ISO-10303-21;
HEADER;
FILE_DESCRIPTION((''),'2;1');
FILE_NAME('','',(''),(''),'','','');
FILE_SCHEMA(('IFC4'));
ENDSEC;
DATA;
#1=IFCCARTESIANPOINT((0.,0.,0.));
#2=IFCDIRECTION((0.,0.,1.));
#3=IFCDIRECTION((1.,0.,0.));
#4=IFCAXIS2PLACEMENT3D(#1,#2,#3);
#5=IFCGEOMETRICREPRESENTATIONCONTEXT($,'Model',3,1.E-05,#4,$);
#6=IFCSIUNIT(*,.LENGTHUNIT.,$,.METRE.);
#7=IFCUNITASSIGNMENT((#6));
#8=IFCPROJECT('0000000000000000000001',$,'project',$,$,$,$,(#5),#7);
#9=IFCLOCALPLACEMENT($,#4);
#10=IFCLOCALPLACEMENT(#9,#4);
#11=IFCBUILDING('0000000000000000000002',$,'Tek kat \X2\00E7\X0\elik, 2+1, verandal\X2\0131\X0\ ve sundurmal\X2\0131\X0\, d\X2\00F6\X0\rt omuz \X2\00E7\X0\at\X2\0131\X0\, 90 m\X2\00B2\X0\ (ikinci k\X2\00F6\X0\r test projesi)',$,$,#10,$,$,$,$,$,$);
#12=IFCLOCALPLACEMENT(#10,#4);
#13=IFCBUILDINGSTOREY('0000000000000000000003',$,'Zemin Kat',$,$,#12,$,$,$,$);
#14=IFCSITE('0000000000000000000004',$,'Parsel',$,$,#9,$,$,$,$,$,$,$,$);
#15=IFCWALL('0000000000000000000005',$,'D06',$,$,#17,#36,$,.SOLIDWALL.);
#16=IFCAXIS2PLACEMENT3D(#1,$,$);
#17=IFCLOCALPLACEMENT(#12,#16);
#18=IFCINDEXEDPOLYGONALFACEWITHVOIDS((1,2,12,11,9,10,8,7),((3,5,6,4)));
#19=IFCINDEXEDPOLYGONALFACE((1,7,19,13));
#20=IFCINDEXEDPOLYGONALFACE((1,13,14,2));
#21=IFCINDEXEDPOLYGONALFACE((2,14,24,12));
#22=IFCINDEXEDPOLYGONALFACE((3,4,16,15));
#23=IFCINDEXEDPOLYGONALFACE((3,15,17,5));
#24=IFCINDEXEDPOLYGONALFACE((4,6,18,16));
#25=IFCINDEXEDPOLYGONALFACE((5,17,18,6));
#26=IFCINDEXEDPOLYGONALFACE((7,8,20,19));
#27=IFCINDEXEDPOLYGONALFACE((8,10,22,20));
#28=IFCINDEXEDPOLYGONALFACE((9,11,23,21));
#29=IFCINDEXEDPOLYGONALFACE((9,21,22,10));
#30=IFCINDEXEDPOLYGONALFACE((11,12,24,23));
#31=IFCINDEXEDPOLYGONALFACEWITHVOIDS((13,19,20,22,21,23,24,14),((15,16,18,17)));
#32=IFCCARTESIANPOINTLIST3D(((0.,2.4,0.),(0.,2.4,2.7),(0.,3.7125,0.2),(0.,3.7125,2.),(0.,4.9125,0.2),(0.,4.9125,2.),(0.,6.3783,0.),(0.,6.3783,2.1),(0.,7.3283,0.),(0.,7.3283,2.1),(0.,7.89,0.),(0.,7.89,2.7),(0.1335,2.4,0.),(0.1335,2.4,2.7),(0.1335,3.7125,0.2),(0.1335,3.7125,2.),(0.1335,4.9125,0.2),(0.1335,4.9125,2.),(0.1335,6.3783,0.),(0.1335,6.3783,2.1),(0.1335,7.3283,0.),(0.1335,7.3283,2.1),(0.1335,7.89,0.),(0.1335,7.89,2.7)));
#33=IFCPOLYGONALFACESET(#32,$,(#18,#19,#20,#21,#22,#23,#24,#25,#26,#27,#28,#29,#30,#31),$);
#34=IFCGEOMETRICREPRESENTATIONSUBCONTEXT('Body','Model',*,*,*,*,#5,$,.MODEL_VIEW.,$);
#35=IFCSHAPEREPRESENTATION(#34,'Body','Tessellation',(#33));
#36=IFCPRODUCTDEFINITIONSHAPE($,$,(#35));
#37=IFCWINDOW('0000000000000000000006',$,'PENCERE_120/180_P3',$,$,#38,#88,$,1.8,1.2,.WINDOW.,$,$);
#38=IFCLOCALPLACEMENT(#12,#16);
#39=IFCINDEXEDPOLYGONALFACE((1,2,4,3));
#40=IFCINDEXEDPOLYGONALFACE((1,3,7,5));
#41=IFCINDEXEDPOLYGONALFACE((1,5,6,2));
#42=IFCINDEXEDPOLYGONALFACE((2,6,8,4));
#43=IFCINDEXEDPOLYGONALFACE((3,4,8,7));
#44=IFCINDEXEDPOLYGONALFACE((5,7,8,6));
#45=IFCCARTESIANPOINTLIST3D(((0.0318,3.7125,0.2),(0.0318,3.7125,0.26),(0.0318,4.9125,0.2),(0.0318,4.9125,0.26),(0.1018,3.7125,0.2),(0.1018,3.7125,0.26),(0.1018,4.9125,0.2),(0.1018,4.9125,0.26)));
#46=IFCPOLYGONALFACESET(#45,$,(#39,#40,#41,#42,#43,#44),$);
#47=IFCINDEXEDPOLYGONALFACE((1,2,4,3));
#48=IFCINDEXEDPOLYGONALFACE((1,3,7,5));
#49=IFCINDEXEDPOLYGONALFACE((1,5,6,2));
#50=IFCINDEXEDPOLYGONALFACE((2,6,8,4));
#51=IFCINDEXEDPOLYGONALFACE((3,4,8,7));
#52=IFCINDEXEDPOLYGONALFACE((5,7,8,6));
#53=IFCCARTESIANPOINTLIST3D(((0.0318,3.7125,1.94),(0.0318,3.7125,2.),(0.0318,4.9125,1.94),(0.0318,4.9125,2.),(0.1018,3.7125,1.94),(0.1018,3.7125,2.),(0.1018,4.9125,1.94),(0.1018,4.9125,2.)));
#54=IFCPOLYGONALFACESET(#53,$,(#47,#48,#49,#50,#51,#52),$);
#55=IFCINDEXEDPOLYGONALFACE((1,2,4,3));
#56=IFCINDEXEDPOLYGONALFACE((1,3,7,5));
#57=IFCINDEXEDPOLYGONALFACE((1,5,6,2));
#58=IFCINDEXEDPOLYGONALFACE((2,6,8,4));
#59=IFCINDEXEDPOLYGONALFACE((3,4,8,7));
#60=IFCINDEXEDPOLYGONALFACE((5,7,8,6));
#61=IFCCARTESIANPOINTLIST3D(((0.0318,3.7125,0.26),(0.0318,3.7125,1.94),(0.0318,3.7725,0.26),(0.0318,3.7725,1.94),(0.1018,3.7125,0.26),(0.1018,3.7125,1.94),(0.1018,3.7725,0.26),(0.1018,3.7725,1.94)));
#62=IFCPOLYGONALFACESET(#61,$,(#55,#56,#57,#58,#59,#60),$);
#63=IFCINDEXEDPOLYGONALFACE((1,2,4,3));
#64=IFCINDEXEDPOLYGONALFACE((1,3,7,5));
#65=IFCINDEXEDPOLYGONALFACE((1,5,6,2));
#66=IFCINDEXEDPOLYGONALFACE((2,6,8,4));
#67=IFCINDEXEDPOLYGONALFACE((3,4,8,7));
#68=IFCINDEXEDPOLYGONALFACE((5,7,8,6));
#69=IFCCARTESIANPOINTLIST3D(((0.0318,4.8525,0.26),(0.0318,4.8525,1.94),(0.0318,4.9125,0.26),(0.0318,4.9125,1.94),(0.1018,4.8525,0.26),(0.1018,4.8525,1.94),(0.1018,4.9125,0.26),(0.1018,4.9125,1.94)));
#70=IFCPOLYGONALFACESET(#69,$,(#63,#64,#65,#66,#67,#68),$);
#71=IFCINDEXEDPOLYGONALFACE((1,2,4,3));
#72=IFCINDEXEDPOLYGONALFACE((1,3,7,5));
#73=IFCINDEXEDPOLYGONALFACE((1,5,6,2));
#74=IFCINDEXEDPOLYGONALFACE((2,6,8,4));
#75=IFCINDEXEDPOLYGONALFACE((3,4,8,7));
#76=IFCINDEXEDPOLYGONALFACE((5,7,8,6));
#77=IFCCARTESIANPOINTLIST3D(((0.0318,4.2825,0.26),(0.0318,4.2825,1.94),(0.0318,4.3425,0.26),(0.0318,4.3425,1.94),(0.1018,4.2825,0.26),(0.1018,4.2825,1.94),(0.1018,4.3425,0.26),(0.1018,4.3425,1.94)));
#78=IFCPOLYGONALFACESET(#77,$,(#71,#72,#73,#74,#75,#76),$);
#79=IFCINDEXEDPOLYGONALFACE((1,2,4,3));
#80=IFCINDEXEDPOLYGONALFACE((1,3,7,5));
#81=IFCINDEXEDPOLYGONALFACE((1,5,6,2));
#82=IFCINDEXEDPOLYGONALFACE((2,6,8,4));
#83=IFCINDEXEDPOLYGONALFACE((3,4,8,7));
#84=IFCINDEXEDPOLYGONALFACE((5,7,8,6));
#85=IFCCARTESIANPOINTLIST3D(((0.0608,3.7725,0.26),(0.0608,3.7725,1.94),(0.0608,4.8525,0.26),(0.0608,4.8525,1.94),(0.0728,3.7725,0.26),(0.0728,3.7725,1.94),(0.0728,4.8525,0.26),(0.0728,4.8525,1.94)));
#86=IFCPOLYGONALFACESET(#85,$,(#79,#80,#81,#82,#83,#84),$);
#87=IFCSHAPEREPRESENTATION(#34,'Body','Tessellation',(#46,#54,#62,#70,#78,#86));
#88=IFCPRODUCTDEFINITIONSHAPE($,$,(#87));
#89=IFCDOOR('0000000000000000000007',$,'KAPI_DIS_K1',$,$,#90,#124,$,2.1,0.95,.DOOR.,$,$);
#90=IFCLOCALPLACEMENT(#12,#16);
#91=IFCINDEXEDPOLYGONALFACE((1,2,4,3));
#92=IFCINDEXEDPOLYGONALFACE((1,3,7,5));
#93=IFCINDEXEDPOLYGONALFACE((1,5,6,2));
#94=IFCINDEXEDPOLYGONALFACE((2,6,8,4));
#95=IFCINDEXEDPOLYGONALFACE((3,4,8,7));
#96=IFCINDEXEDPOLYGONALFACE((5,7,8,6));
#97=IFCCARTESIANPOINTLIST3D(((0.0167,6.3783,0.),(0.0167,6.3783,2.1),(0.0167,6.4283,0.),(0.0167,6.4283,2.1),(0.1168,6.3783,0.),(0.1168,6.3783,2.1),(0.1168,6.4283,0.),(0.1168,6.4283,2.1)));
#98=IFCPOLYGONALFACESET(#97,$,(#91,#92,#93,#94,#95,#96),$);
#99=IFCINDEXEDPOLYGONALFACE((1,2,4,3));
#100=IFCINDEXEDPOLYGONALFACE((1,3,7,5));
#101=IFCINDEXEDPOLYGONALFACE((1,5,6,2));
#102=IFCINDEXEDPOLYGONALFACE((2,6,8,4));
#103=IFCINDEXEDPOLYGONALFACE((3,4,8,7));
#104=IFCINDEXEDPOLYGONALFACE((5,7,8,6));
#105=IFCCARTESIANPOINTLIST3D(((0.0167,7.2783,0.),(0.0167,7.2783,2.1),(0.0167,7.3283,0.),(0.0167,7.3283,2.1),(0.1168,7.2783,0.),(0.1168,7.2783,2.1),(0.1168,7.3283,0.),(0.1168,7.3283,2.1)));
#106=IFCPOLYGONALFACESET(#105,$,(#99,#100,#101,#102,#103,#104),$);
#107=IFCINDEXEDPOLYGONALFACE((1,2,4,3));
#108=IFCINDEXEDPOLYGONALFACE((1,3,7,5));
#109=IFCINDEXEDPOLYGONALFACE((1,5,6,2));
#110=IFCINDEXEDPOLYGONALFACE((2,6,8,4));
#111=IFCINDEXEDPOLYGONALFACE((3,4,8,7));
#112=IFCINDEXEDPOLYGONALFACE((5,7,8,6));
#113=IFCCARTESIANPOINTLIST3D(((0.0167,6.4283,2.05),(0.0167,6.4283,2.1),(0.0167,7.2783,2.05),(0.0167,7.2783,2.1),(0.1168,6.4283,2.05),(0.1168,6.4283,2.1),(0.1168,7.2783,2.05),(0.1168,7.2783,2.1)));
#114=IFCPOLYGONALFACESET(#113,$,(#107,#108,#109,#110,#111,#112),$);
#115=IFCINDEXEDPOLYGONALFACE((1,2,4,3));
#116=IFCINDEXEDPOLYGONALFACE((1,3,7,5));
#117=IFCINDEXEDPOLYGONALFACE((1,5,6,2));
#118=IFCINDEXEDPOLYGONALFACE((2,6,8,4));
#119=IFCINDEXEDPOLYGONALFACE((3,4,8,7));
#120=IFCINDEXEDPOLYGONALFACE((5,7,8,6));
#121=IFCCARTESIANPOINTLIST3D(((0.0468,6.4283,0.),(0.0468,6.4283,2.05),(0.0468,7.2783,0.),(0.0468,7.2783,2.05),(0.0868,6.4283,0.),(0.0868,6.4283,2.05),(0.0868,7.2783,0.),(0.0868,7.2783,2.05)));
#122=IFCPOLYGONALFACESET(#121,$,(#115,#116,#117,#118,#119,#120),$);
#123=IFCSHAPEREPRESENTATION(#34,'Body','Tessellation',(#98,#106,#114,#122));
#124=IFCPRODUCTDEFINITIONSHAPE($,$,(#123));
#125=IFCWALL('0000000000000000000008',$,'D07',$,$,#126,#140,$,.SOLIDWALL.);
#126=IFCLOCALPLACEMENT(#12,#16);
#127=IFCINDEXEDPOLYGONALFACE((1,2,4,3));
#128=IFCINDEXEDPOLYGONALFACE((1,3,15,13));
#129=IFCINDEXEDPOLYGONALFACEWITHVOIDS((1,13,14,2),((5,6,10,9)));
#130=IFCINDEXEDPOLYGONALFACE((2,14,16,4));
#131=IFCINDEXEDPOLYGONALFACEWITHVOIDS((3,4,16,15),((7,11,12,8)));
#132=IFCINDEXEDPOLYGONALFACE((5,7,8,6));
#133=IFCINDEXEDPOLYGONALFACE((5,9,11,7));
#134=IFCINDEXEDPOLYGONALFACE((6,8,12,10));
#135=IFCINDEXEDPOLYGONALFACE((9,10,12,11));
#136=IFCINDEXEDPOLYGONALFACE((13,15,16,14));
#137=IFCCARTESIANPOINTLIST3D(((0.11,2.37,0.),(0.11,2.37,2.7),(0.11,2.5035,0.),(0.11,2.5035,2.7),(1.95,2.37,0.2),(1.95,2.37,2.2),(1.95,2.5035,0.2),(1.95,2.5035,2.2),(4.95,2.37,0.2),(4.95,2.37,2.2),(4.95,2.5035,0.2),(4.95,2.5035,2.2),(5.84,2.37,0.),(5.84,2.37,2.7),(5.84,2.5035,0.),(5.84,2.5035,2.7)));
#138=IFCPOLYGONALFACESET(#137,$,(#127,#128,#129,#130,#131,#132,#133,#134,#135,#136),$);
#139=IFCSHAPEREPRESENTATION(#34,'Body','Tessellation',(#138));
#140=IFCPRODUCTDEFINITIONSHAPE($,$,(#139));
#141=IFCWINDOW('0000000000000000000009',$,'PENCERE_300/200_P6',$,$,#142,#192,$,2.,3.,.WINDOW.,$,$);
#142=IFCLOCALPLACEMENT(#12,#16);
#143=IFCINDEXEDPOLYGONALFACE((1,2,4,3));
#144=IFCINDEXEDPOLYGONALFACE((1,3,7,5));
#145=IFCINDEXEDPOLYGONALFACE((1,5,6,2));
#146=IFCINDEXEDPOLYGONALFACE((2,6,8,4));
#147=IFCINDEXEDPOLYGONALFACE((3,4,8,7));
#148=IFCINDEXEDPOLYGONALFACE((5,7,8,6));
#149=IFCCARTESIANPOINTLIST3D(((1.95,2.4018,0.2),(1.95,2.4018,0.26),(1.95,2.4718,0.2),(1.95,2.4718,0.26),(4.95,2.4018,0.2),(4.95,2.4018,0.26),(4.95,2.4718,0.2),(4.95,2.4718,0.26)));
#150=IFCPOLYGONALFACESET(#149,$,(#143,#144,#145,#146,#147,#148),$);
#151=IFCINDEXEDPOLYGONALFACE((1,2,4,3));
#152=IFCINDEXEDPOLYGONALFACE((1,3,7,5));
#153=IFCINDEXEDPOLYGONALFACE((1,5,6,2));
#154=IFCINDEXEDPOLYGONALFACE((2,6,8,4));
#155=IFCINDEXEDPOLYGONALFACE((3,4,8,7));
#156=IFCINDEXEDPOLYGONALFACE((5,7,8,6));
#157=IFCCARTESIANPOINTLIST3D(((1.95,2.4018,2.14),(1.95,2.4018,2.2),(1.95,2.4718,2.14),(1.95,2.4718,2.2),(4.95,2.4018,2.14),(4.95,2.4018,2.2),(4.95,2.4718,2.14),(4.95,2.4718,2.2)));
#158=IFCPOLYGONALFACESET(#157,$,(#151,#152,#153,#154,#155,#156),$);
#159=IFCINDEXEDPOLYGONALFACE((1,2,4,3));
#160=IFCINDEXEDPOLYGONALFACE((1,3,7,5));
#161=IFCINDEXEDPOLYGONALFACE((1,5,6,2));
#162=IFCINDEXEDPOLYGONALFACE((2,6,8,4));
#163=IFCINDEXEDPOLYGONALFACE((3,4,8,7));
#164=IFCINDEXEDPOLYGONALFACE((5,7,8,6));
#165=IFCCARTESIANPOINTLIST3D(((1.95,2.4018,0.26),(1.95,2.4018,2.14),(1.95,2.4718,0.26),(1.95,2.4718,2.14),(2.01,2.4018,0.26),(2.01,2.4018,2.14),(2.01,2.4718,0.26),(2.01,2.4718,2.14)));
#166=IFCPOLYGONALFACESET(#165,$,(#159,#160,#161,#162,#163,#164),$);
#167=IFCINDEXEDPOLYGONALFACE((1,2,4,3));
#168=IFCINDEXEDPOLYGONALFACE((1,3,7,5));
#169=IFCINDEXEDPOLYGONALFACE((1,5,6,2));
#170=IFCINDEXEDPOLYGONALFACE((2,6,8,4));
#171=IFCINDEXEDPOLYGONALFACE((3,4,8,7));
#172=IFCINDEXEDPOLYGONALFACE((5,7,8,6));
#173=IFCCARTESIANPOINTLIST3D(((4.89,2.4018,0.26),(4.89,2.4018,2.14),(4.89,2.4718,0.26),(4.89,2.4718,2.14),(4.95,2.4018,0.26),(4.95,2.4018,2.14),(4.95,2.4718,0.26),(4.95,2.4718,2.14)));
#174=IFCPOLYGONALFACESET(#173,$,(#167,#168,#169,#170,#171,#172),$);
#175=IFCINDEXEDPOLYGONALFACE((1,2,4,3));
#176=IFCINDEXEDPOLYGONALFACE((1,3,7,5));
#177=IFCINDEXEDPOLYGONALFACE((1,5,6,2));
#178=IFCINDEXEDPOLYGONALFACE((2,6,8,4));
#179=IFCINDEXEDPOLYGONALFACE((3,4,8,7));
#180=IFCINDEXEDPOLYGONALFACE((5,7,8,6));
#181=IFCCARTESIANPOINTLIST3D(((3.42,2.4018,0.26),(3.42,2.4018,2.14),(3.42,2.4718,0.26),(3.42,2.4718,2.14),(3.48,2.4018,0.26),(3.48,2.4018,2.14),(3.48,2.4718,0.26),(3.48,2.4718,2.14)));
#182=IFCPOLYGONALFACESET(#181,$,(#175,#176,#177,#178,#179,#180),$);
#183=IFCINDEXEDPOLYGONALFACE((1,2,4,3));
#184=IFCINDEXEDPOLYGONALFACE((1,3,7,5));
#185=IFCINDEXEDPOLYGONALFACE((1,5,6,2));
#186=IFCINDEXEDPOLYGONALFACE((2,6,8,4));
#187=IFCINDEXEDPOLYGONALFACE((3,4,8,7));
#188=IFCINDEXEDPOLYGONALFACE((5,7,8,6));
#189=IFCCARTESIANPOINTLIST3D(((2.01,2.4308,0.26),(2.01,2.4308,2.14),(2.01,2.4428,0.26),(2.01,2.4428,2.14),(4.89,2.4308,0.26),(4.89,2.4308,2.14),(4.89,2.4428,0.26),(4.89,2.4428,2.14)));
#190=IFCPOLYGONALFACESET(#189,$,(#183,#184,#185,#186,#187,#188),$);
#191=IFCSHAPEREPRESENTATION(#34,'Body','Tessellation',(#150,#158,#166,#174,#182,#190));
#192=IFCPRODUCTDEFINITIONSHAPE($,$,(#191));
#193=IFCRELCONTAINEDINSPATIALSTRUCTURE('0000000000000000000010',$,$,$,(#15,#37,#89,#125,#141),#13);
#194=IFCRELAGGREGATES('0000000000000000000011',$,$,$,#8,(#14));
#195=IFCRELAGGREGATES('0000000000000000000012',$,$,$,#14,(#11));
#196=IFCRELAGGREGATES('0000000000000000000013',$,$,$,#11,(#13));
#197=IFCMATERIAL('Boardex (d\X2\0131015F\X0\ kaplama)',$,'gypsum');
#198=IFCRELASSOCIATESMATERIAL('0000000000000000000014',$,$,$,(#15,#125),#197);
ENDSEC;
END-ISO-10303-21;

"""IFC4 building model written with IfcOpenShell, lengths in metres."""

from ifc_helpers import new_model, si_unit, frame, origin_with_axes, place, context, subcontext, project, spatial, line, indexed_curve, outline, extrude, material, element, fill, save


model = new_model("IFC4")

# Units and contexts
model_context = context("Model", 3, precision=1e-05, world=origin_with_axes())
body_context = subcontext(model_context, "Body", "Model", "MODEL_VIEW")
ifc_project = project(units=[si_unit("LENGTHUNIT", "METRE")], contexts=[model_context])

# Site, building, storey
site_placement = place(None, origin_with_axes())
site = spatial("IfcSite", under=ifc_project, at=site_placement, Name="Parsel")
building_placement = place(site_placement, origin_with_axes())
building = spatial("IfcBuilding", under=site, at=building_placement, Name="Tek kat çelik, 2+1, verandalı ve sundurmalı, dört omuz çatı, 90 m² (ikinci kör test projesi)")
storey_placement = place(building_placement, origin_with_axes())
storey = spatial("IfcBuildingStorey", under=building, at=storey_placement, Name="Zemin Kat")

# Shared definitions
ifc_material_1 = material(Name="Boardex (dış kaplama)", Category="gypsum")

# Wall, openings, window, door
wall_1_placement = place(storey_placement, origin_with_axes())
wall_1 = element("IfcWall", 1, at=wall_1_placement, inside=storey, material=ifc_material_1, Name="D06", PredefinedType="SOLIDWALL", context=body_context, shape_type="SweptSolid", body=[
    extrude(outline(indexed_curve([(0.0, 0.0), (0.1335, 0.0), (0.1335, 5.49), (0.0, 5.49)], segments=[line(1, 2, 3, 4, 1)])), frame((0.0, 2.4, 0.0), z_axis=(0.0, 0.0, 1.0), x_axis=(1.0, 0.0, 0.0)), (0.0, 0.0, 1.0), 2.7),
])
opening_1_placement = place(wall_1_placement, origin_with_axes())
opening_1 = element("IfcOpeningElement", 2, at=opening_1_placement, cuts=wall_1, PredefinedType="OPENING", context=body_context, shape_type="SweptSolid", body=[
    extrude(outline(indexed_curve([(0.0, 0.0), (0.1735, 0.0), (0.1735, 1.2), (0.0, 1.2)], segments=[line(1, 2, 3, 4, 1)])), frame((-0.02, 3.7125, 0.2), z_axis=(0.0, 0.0, 1.0), x_axis=(1.0, 0.0, 0.0)), (0.0, 0.0, 1.0), 1.8),
])
opening_2_placement = place(wall_1_placement, origin_with_axes())
opening_2 = element("IfcOpeningElement", 3, at=opening_2_placement, cuts=wall_1, PredefinedType="OPENING", context=body_context, shape_type="SweptSolid", body=[
    extrude(outline(indexed_curve([(0.0, 0.0), (0.1735, 0.0), (0.1735, 0.95), (0.0, 0.95)], segments=[line(1, 2, 3, 4, 1)])), frame((-0.02, 6.3783, 0.0), z_axis=(0.0, 0.0, 1.0), x_axis=(1.0, 0.0, 0.0)), (0.0, 0.0, 1.0), 2.1),
])
window_1_placement = place(storey_placement, origin_with_axes())
window_1 = element("IfcWindow", 4, at=window_1_placement, inside=storey, Name="PENCERE_120/180_P3", OverallHeight=1.8, OverallWidth=1.2, PredefinedType="WINDOW", context=body_context, shape_type="SweptSolid", body=[
    extrude(outline(indexed_curve([(0.0, 0.0), (0.07, 0.0), (0.07, 1.2), (0.0, 1.2)], segments=[line(1, 2, 3, 4, 1)])), frame((0.0318, 3.7125, 0.2), z_axis=(0.0, 0.0, 1.0), x_axis=(1.0, 0.0, 0.0)), (0.0, 0.0, 1.0), 0.06),
    extrude(outline(indexed_curve([(0.0, 0.0), (0.07, 0.0), (0.07, 1.2), (0.0, 1.2)], segments=[line(1, 2, 3, 4, 1)])), frame((0.0318, 3.7125, 1.94), z_axis=(0.0, 0.0, 1.0), x_axis=(1.0, 0.0, 0.0)), (0.0, 0.0, 1.0), 0.06),
    extrude(outline(indexed_curve([(0.0, 0.0), (0.07, 0.0), (0.07, 0.06), (0.0, 0.06)], segments=[line(1, 2, 3, 4, 1)])), frame((0.0318, 3.7125, 0.26), z_axis=(0.0, 0.0, 1.0), x_axis=(1.0, 0.0, 0.0)), (0.0, 0.0, 1.0), 1.68),
    extrude(outline(indexed_curve([(0.0, 0.0), (0.07, 0.0), (0.07, 0.06), (0.0, 0.06)], segments=[line(1, 2, 3, 4, 1)])), frame((0.0318, 4.8525, 0.26), z_axis=(0.0, 0.0, 1.0), x_axis=(1.0, 0.0, 0.0)), (0.0, 0.0, 1.0), 1.68),
    extrude(outline(indexed_curve([(0.0, 0.0), (0.07, 0.0), (0.07, 0.06), (0.0, 0.06)], segments=[line(1, 2, 3, 4, 1)])), frame((0.0318, 4.2825, 0.26), z_axis=(0.0, 0.0, 1.0), x_axis=(1.0, 0.0, 0.0)), (0.0, 0.0, 1.0), 1.68),
    extrude(outline(indexed_curve([(0.0, 0.0), (0.012, 0.0), (0.012, 1.08), (0.0, 1.08)], segments=[line(1, 2, 3, 4, 1)])), frame((0.0608, 3.7725, 0.26), z_axis=(0.0, 0.0, 1.0), x_axis=(1.0, 0.0, 0.0)), (0.0, 0.0, 1.0), 1.68),
])
fill(opening_1, window_1)
door_1_placement = place(storey_placement, origin_with_axes())
door_1 = element("IfcDoor", 5, at=door_1_placement, inside=storey, Name="KAPI_DIS_K1", OverallHeight=2.1, OverallWidth=0.95, PredefinedType="DOOR", context=body_context, shape_type="SweptSolid", body=[
    extrude(outline(indexed_curve([(0.0, 0.0), (0.1, 0.0), (0.1, 0.05), (0.0, 0.05)], segments=[line(1, 2, 3, 4, 1)])), frame((0.0167, 6.3783, 0.0), z_axis=(0.0, 0.0, 1.0), x_axis=(1.0, 0.0, 0.0)), (0.0, 0.0, 1.0), 2.1),
    extrude(outline(indexed_curve([(0.0, 0.0), (0.1, 0.0), (0.1, 0.05), (0.0, 0.05)], segments=[line(1, 2, 3, 4, 1)])), frame((0.0167, 7.2783, 0.0), z_axis=(0.0, 0.0, 1.0), x_axis=(1.0, 0.0, 0.0)), (0.0, 0.0, 1.0), 2.1),
    extrude(outline(indexed_curve([(0.0, 0.0), (0.1, 0.0), (0.1, 0.85), (0.0, 0.85)], segments=[line(1, 2, 3, 4, 1)])), frame((0.0167, 6.4283, 2.05), z_axis=(0.0, 0.0, 1.0), x_axis=(1.0, 0.0, 0.0)), (0.0, 0.0, 1.0), 0.05),
    extrude(outline(indexed_curve([(0.0, 0.0), (0.04, 0.0), (0.04, 0.85), (0.0, 0.85)], segments=[line(1, 2, 3, 4, 1)])), frame((0.0467, 6.4283, 0.0), z_axis=(0.0, 0.0, 1.0), x_axis=(1.0, 0.0, 0.0)), (0.0, 0.0, 1.0), 2.05),
])
fill(opening_2, door_1)

# Wall, opening, window
wall_2_placement = place(storey_placement, origin_with_axes())
wall_2 = element("IfcWall", 6, at=wall_2_placement, inside=storey, material=ifc_material_1, Name="D07", PredefinedType="SOLIDWALL", context=body_context, shape_type="SweptSolid", body=[
    extrude(outline(indexed_curve([(0.0, 0.0), (5.73, 0.0), (5.73, 0.1335), (0.0, 0.1335)], segments=[line(1, 2, 3, 4, 1)])), frame((0.11, 2.37, 0.0), z_axis=(0.0, 0.0, 1.0), x_axis=(1.0, 0.0, 0.0)), (0.0, 0.0, 1.0), 2.7),
])
opening_3_placement = place(wall_2_placement, origin_with_axes())
opening_3 = element("IfcOpeningElement", 7, at=opening_3_placement, cuts=wall_2, PredefinedType="OPENING", context=body_context, shape_type="SweptSolid", body=[
    extrude(outline(indexed_curve([(0.0, 0.0), (3.0, 0.0), (3.0, 0.1735), (0.0, 0.1735)], segments=[line(1, 2, 3, 4, 1)])), frame((1.95, 2.35, 0.2), z_axis=(0.0, 0.0, 1.0), x_axis=(1.0, 0.0, 0.0)), (0.0, 0.0, 1.0), 2.0),
])
window_2_placement = place(storey_placement, origin_with_axes())
window_2 = element("IfcWindow", 8, at=window_2_placement, inside=storey, Name="PENCERE_300/200_P6", OverallHeight=2.0, OverallWidth=3.0, PredefinedType="WINDOW", context=body_context, shape_type="SweptSolid", body=[
    extrude(outline(indexed_curve([(0.0, 0.0), (3.0, 0.0), (3.0, 0.07), (0.0, 0.07)], segments=[line(1, 2, 3, 4, 1)])), frame((1.95, 2.4018, 0.2), z_axis=(0.0, 0.0, 1.0), x_axis=(1.0, 0.0, 0.0)), (0.0, 0.0, 1.0), 0.06),
    extrude(outline(indexed_curve([(0.0, 0.0), (3.0, 0.0), (3.0, 0.07), (0.0, 0.07)], segments=[line(1, 2, 3, 4, 1)])), frame((1.95, 2.4018, 2.14), z_axis=(0.0, 0.0, 1.0), x_axis=(1.0, 0.0, 0.0)), (0.0, 0.0, 1.0), 0.06),
    extrude(outline(indexed_curve([(0.0, 0.0), (0.06, 0.0), (0.06, 0.07), (0.0, 0.07)], segments=[line(1, 2, 3, 4, 1)])), frame((1.95, 2.4018, 0.26), z_axis=(0.0, 0.0, 1.0), x_axis=(1.0, 0.0, 0.0)), (0.0, 0.0, 1.0), 1.88),
    extrude(outline(indexed_curve([(0.0, 0.0), (0.06, 0.0), (0.06, 0.07), (0.0, 0.07)], segments=[line(1, 2, 3, 4, 1)])), frame((4.89, 2.4018, 0.26), z_axis=(0.0, 0.0, 1.0), x_axis=(1.0, 0.0, 0.0)), (0.0, 0.0, 1.0), 1.88),
    extrude(outline(indexed_curve([(0.0, 0.0), (0.06, 0.0), (0.06, 0.07), (0.0, 0.07)], segments=[line(1, 2, 3, 4, 1)])), frame((3.42, 2.4018, 0.26), z_axis=(0.0, 0.0, 1.0), x_axis=(1.0, 0.0, 0.0)), (0.0, 0.0, 1.0), 1.88),
    extrude(outline(indexed_curve([(0.0, 0.0), (2.88, 0.0), (2.88, 0.012), (0.0, 0.012)], segments=[line(1, 2, 3, 4, 1)])), frame((2.01, 2.4308, 0.26), z_axis=(0.0, 0.0, 1.0), x_axis=(1.0, 0.0, 0.0)), (0.0, 0.0, 1.0), 1.88),
])
fill(opening_3, window_2)

save(model, "model.ifc")
